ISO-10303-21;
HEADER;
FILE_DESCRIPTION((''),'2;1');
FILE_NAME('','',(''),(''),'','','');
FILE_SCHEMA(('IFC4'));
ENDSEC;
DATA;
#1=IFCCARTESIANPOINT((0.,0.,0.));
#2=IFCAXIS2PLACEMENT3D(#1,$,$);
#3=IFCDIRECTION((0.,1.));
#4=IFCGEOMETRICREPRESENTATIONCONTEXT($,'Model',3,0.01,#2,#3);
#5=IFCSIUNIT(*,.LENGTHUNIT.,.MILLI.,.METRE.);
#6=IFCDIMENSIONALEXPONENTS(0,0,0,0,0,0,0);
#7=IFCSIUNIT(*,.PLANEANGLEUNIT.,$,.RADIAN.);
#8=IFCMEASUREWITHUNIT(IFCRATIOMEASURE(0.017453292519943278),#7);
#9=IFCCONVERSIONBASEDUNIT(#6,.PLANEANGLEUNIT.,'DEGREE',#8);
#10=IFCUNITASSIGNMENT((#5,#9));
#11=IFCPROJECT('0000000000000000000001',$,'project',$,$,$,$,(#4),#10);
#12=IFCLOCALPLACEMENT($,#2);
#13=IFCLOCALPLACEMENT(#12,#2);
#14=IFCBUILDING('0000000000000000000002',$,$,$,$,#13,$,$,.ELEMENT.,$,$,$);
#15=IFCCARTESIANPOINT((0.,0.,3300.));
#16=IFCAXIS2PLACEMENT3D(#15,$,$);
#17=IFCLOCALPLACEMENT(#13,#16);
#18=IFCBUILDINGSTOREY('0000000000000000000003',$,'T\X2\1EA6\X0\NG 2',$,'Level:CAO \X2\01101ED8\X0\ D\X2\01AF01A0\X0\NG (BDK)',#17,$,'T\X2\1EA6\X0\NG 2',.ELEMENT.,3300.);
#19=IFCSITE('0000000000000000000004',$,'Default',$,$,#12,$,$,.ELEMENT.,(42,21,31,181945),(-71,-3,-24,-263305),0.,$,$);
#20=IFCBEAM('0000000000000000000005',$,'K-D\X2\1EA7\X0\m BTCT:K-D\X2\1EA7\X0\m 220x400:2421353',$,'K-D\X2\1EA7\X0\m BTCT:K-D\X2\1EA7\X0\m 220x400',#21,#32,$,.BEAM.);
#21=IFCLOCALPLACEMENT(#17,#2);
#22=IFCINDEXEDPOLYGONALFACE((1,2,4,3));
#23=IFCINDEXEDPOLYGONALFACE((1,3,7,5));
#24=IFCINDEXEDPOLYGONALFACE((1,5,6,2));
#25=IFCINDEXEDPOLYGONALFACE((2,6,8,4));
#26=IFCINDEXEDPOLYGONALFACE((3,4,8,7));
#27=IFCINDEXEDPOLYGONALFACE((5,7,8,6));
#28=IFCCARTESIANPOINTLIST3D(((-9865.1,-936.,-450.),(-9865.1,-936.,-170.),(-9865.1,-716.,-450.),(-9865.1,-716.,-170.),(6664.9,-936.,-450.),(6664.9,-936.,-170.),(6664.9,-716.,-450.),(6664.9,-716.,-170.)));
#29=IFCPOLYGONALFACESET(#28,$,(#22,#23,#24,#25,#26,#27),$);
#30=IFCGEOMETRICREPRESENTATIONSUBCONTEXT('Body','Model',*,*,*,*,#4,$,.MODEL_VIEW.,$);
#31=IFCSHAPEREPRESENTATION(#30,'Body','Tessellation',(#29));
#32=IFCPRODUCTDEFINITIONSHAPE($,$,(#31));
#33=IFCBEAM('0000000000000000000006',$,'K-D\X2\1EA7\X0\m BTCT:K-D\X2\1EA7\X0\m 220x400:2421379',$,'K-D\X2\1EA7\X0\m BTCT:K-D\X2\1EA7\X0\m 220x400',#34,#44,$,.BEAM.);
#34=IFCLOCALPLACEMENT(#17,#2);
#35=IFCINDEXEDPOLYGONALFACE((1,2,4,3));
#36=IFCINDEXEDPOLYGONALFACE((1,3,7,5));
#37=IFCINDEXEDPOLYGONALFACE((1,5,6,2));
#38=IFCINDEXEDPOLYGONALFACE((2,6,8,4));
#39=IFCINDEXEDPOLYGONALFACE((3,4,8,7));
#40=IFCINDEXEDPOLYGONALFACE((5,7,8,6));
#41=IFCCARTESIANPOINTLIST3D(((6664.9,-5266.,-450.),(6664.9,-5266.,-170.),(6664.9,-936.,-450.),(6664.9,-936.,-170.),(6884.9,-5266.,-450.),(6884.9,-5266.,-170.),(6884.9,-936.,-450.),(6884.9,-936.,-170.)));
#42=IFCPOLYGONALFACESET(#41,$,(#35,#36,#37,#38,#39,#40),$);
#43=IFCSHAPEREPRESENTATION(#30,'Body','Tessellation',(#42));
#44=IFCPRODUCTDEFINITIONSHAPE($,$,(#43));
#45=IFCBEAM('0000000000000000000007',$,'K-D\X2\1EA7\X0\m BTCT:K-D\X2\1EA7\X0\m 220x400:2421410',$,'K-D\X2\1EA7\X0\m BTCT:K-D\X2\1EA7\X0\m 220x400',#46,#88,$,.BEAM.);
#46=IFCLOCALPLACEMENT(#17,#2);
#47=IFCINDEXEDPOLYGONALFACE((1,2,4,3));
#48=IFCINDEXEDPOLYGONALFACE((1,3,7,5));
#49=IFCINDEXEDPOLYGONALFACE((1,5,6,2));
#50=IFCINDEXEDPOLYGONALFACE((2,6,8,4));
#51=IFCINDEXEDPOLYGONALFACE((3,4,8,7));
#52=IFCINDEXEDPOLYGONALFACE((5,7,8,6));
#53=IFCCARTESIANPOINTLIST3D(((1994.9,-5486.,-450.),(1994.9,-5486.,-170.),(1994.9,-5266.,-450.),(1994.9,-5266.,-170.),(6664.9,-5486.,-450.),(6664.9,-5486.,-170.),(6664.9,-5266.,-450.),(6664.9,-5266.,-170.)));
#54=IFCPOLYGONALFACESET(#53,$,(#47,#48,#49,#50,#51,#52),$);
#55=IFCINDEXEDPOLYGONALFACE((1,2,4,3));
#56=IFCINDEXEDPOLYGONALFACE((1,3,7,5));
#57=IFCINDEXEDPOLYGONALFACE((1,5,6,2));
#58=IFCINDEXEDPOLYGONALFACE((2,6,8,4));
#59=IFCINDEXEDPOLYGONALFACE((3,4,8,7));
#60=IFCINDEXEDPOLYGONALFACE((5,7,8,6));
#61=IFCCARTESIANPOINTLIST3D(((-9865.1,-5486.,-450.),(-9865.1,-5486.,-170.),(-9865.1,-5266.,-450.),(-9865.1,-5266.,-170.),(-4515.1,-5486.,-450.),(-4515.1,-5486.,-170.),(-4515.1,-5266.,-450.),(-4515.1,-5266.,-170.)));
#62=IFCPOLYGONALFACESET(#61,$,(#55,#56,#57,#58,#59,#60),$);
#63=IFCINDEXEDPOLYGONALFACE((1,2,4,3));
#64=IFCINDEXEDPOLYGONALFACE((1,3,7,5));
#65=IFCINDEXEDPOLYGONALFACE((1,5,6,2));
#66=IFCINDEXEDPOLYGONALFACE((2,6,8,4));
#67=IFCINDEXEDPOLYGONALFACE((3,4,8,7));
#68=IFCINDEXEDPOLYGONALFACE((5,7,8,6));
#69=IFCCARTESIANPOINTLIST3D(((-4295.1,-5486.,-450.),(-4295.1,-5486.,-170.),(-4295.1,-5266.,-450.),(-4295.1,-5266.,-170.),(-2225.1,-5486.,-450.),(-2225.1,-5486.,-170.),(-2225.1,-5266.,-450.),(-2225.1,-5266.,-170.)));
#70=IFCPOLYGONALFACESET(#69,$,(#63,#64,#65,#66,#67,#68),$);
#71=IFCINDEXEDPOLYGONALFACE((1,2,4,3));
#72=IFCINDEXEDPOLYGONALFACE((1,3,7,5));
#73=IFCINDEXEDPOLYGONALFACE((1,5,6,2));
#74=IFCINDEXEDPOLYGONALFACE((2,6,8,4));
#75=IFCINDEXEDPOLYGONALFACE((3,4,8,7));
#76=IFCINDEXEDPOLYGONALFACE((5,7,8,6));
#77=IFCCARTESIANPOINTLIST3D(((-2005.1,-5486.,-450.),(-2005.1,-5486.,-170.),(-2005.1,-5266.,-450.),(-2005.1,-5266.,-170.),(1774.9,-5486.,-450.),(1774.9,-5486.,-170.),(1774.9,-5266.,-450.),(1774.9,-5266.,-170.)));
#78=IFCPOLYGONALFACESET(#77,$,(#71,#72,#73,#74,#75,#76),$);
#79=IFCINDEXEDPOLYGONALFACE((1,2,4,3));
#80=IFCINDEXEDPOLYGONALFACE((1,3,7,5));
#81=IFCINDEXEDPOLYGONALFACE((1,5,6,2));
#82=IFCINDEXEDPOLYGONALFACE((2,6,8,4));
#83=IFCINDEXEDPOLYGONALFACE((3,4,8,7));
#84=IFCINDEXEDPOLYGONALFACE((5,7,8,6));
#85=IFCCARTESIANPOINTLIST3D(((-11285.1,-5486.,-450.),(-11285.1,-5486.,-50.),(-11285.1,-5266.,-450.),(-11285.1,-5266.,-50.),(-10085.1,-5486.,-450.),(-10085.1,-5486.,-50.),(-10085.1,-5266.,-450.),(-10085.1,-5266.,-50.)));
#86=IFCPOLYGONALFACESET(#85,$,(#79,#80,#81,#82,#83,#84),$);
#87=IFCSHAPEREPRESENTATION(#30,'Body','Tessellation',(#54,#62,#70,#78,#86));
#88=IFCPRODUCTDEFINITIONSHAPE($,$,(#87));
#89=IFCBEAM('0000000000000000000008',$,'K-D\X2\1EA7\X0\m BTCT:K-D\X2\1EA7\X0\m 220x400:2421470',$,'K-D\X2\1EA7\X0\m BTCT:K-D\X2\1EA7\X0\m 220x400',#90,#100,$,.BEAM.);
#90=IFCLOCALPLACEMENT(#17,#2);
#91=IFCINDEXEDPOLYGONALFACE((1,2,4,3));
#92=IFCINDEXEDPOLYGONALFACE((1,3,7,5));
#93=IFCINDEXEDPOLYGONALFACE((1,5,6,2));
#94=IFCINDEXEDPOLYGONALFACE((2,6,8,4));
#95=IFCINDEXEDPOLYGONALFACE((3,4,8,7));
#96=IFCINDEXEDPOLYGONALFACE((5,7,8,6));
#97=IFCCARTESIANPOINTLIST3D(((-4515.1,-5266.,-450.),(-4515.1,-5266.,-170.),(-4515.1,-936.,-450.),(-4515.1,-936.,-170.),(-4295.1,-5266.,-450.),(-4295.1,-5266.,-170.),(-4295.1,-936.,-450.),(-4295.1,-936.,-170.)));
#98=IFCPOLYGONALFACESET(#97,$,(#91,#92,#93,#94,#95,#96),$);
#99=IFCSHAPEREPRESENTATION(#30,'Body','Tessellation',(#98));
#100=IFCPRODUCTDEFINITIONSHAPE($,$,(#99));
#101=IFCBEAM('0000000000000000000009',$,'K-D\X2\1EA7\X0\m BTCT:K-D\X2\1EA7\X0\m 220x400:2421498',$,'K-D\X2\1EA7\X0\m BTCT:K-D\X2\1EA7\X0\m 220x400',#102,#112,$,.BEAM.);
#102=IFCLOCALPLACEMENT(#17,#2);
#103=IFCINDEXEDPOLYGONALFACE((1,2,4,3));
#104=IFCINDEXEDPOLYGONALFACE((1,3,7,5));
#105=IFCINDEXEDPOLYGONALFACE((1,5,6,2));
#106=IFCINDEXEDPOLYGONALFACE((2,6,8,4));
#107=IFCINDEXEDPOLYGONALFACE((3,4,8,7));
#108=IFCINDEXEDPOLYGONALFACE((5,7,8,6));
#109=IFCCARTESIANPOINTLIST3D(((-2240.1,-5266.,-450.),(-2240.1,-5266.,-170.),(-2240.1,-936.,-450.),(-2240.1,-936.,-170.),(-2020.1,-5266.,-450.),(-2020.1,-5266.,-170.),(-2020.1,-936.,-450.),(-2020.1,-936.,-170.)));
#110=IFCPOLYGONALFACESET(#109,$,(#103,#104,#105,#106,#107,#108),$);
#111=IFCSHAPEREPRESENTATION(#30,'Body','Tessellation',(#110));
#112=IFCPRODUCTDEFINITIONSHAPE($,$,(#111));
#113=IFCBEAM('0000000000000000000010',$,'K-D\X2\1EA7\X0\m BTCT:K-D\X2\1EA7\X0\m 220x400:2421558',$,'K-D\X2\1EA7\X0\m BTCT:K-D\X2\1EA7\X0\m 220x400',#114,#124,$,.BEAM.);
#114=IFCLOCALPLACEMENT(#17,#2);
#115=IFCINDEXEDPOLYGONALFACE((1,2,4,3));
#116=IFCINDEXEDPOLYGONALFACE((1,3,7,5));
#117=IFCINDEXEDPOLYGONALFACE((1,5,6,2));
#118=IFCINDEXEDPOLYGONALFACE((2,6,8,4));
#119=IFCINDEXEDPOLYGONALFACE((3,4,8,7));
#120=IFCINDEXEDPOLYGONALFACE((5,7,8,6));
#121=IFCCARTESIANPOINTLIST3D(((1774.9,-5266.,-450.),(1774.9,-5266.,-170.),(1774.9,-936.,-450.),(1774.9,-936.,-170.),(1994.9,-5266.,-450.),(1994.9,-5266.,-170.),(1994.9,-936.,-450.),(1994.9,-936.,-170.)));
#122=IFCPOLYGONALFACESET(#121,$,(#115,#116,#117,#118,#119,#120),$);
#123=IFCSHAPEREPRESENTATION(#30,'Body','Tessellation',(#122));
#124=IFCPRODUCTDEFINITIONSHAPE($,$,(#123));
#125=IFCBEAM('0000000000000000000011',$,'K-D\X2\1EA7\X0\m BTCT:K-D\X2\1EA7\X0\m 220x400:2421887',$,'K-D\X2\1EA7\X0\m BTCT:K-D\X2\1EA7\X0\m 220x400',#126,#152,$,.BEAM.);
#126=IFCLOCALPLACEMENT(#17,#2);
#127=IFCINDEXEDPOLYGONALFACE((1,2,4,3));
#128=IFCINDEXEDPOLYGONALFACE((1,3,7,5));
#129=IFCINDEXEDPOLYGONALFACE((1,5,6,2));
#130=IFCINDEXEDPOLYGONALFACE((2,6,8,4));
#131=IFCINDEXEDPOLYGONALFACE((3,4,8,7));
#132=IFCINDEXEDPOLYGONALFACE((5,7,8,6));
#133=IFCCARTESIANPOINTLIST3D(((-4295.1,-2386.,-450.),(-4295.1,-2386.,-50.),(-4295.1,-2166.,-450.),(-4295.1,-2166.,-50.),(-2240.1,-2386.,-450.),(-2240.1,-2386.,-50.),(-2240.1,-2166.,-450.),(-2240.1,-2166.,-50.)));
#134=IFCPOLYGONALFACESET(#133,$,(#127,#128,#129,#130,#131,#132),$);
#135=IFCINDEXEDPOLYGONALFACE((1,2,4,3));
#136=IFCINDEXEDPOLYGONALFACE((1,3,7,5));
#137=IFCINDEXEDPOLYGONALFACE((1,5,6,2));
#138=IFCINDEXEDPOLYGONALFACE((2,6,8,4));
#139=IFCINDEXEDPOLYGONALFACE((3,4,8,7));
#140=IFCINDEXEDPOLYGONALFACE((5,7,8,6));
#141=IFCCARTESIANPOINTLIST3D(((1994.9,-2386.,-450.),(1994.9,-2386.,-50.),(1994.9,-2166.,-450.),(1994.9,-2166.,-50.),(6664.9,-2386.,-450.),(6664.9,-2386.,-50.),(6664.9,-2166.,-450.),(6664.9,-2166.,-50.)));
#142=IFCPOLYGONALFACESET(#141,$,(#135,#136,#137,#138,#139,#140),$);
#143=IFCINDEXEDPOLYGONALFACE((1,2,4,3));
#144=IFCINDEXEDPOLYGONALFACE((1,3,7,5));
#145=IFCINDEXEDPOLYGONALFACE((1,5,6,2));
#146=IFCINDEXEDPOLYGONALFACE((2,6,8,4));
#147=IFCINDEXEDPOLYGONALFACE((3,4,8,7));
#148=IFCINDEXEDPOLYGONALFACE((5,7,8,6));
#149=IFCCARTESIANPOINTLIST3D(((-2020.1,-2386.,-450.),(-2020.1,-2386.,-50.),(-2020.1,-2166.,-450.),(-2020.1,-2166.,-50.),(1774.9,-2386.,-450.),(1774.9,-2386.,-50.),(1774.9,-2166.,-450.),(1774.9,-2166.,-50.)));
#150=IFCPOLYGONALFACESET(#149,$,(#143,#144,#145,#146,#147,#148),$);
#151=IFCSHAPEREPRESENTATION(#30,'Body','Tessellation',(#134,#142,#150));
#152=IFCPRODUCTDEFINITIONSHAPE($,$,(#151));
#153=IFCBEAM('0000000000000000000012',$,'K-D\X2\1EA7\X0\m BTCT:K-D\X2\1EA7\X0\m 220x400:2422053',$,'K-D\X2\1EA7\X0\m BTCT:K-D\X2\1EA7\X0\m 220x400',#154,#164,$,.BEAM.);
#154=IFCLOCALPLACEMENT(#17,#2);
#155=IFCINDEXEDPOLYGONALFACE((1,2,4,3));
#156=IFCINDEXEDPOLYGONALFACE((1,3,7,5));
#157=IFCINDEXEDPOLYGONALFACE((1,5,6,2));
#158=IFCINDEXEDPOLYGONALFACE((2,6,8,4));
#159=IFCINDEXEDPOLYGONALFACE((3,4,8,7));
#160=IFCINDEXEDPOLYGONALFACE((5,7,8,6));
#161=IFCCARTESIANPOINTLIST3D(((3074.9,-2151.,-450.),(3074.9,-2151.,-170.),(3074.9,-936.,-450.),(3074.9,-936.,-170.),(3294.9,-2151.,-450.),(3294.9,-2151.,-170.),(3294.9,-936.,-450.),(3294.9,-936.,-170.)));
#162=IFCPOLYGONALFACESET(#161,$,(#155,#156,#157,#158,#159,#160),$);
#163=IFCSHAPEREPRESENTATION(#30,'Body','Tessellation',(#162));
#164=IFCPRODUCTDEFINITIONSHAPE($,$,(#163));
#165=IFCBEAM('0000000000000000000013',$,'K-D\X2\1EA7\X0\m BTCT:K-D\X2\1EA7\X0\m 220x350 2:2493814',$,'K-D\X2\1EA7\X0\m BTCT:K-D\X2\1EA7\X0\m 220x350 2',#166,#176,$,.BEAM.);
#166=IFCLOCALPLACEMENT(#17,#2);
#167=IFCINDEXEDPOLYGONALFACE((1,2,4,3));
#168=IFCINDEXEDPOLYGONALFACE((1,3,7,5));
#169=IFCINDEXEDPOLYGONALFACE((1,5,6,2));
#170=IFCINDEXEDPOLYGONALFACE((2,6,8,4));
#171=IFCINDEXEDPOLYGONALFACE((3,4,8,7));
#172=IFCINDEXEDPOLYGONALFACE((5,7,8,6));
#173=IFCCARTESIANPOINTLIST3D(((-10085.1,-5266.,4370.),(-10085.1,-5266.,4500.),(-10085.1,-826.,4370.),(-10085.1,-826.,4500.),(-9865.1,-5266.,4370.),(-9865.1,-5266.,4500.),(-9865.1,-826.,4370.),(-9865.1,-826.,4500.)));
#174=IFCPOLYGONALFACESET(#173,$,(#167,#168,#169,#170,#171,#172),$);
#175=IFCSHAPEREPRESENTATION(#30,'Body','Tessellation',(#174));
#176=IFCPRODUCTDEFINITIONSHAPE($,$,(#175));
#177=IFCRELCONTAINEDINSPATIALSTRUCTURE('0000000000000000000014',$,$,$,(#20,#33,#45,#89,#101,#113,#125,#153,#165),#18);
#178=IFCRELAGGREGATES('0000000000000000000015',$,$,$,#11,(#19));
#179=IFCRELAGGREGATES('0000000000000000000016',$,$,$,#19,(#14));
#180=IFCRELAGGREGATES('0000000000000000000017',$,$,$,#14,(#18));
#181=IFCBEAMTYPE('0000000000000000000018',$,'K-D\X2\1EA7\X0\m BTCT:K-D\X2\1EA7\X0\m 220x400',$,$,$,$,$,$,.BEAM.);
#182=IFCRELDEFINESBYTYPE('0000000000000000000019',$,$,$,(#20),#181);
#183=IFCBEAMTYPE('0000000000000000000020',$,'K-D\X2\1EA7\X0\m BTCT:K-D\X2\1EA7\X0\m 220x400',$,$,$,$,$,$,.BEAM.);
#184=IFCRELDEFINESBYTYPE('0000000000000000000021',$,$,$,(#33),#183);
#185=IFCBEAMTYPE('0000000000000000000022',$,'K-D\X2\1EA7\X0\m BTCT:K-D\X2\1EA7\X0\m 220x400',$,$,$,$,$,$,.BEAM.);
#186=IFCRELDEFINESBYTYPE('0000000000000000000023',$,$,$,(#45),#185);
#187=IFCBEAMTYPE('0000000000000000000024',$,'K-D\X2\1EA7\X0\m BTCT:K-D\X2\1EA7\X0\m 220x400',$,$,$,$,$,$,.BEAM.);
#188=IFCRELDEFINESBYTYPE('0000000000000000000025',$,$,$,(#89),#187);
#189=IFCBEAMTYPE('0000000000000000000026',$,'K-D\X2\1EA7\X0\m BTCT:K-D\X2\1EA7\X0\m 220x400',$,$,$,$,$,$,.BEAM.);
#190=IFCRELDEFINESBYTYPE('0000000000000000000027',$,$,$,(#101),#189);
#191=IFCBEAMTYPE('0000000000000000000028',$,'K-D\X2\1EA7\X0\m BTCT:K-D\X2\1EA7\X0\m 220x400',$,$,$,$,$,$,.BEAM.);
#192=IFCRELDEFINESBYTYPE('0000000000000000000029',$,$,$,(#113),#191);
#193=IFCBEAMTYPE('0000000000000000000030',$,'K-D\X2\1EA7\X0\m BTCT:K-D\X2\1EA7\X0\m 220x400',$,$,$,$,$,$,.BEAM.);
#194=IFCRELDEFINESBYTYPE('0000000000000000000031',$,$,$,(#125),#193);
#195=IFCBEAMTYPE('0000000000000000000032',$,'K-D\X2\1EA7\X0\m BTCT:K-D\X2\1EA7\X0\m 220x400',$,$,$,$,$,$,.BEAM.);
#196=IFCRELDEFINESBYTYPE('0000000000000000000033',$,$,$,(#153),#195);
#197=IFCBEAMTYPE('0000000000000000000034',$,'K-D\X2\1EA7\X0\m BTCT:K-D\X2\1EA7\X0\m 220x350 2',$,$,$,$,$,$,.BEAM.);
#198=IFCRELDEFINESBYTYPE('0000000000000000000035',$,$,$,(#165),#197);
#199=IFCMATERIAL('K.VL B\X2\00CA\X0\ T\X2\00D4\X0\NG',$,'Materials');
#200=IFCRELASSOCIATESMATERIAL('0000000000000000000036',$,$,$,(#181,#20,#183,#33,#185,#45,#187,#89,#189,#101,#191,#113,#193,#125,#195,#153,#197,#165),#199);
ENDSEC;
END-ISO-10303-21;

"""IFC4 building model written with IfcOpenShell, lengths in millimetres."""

from ifc_helpers import new_model, entity, si_unit, converted_unit, direction, frame, origin, place, context, subcontext, project, spatial, indexed_curve, outline, extrude, source, transform, mapped, material, type_object, type_shapes, element, save


model = new_model("IFC4")

# Units and contexts
model_context = context("Model", 3, precision=0.01, world=origin(), true_north=direction((0.0, 1.0)))
body_context = subcontext(model_context, "Body", "Model", "MODEL_VIEW")
ifc_project = project(units=[si_unit("LENGTHUNIT", "METRE", prefix="MILLI"), converted_unit("PLANEANGLEUNIT", "DEGREE", entity("IfcRatioMeasure", 0.017453292519943278), si_unit("PLANEANGLEUNIT", "RADIAN"), dimensions=[0, 0, 0, 0, 0, 0, 0])], contexts=[model_context])

# Site, building, storey
site_placement = place(None, origin())
site = spatial("IfcSite", under=ifc_project, at=site_placement, Name="Default", CompositionType="ELEMENT", RefLatitude=(42, 21, 31, 181945), RefLongitude=(-71, -3, -24, -263305), RefElevation=0.0)
building_placement = place(site_placement, origin())
building = spatial("IfcBuilding", under=site, at=building_placement, CompositionType="ELEMENT")
storey_placement = place(building_placement, frame((0.0, 0.0, 3300.0)))
storey = spatial("IfcBuildingStorey", under=building, at=storey_placement, Name="TẦNG 2", ObjectType="Level:CAO ĐỘ DƯƠNG (BDK)", LongName="TẦNG 2", CompositionType="ELEMENT", Elevation=3300.0)

# Beams
ifc_material_1 = material(Name="K.VL BÊ TÔNG", Category="Materials")
beam_type_1 = type_object("IfcBeamType", Name="K-Dầm BTCT:K-Dầm 220x400", PredefinedType="BEAM", material=ifc_material_1)
shared_shape_1 = source(origin(), body_context, "Body", "SweptSolid", [
    extrude(outline(indexed_curve([(-140.0, -110.0), (140.0, -110.0), (140.0, 110.0), (-140.0, 110.0), (-140.0, -110.0)], self_intersect=False)), frame((-9865.1, -826.0, 2990.0), z_axis=(1.0, 0.0, 0.0), x_axis=(0.0, 0.0, -1.0)), (0.0, 0.0, 1.0), 16530.0),
])
type_shapes(beam_type_1, [shared_shape_1])
beam_1_placement = place(storey_placement, frame((0.0, 0.0, -3300.0)))
element("IfcBeam", 1, at=beam_1_placement, inside=storey, type_object=beam_type_1, material=ifc_material_1, Name="K-Dầm BTCT:K-Dầm 220x400:2421353", ObjectType="K-Dầm BTCT:K-Dầm 220x400", PredefinedType="BEAM", context=body_context, shape_type="MappedRepresentation", body=[
    mapped(shared_shape_1, transform((0.0, 0.0, 0.0), scale=1.0)),
])
beam_type_2 = type_object("IfcBeamType", Name="K-Dầm BTCT:K-Dầm 220x400", PredefinedType="BEAM", material=ifc_material_1)
shared_shape_2 = source(origin(), body_context, "Body", "SweptSolid", [
    extrude(outline(indexed_curve([(-110.0, -140.0), (110.0, -140.0), (110.0, 140.0), (-110.0, 140.0), (-110.0, -140.0)], self_intersect=False)), frame((6774.9, -936.0, 2990.0), z_axis=(0.0, -1.0, 0.0), x_axis=(-1.0, 0.0, 0.0)), (0.0, 0.0, 1.0), 4330.0),
])
type_shapes(beam_type_2, [shared_shape_2])
beam_2_placement = place(storey_placement, frame((0.0, 0.0, -3300.0)))
element("IfcBeam", 2, at=beam_2_placement, inside=storey, type_object=beam_type_2, material=ifc_material_1, Name="K-Dầm BTCT:K-Dầm 220x400:2421379", ObjectType="K-Dầm BTCT:K-Dầm 220x400", PredefinedType="BEAM", context=body_context, shape_type="MappedRepresentation", body=[
    mapped(shared_shape_2, transform((0.0, 0.0, 0.0), scale=1.0)),
])
beam_type_3 = type_object("IfcBeamType", Name="K-Dầm BTCT:K-Dầm 220x400", PredefinedType="BEAM", material=ifc_material_1)
shared_shape_3 = source(origin(), body_context, "Body", "SweptSolid", [
    extrude(outline(indexed_curve([(-140.0, -110.0), (140.0, -110.0), (140.0, 110.0), (-140.0, 110.0), (-140.0, -110.0)], self_intersect=False)), frame((6664.9, -5376.0, 2990.0), z_axis=(-1.0, 0.0, 0.0), x_axis=(0.0, 0.0, -1.0)), (0.0, 0.0, 1.0), 4670.0),
    extrude(outline(indexed_curve([(-140.0, -110.0), (140.0, -110.0), (140.0, 110.0), (-140.0, 110.0), (-140.0, -110.0)], self_intersect=False)), frame((-4515.1, -5376.0, 2990.0), z_axis=(-1.0, 0.0, 0.0), x_axis=(0.0, 0.0, -1.0)), (0.0, 0.0, 1.0), 5350.0),
    extrude(outline(indexed_curve([(-140.0, -110.0), (140.0, -110.0), (140.0, 110.0), (-140.0, 110.0), (-140.0, -110.0)], self_intersect=False)), frame((-2225.1, -5376.0, 2990.0), z_axis=(-1.0, 0.0, 0.0), x_axis=(0.0, 0.0, -1.0)), (0.0, 0.0, 1.0), 2070.0),
    extrude(outline(indexed_curve([(-140.0, -110.0), (140.0, -110.0), (140.0, 110.0), (-140.0, 110.0), (-140.0, -110.0)], self_intersect=False)), frame((1774.9, -5376.0, 2990.0), z_axis=(-1.0, 0.0, 0.0), x_axis=(0.0, 0.0, -1.0)), (0.0, 0.0, 1.0), 3780.0),
    extrude(outline(indexed_curve([(-200.0, -110.0), (200.0, -110.0), (200.0, 110.0), (-200.0, 110.0), (-200.0, -110.0)], self_intersect=False)), frame((-10085.1, -5376.0, 3050.0), z_axis=(-1.0, 0.0, 0.0), x_axis=(0.0, 0.0, -1.0)), (0.0, 0.0, 1.0), 1200.0),
])
type_shapes(beam_type_3, [shared_shape_3])
beam_3_placement = place(storey_placement, frame((0.0, 0.0, -3300.0)))
element("IfcBeam", 3, at=beam_3_placement, inside=storey, type_object=beam_type_3, material=ifc_material_1, Name="K-Dầm BTCT:K-Dầm 220x400:2421410", ObjectType="K-Dầm BTCT:K-Dầm 220x400", PredefinedType="BEAM", context=body_context, shape_type="MappedRepresentation", body=[
    mapped(shared_shape_3, transform((0.0, 0.0, 0.0), scale=1.0)),
])
beam_type_4 = type_object("IfcBeamType", Name="K-Dầm BTCT:K-Dầm 220x400", PredefinedType="BEAM", material=ifc_material_1)
shared_shape_4 = source(origin(), body_context, "Body", "SweptSolid", [
    extrude(outline(indexed_curve([(-110.0, -140.0), (110.0, -140.0), (110.0, 140.0), (-110.0, 140.0), (-110.0, -140.0)], self_intersect=False)), frame((-4405.1, -936.0, 2990.0), z_axis=(0.0, -1.0, 0.0), x_axis=(-1.0, 0.0, 0.0)), (0.0, 0.0, 1.0), 4330.0),
])
type_shapes(beam_type_4, [shared_shape_4])
beam_4_placement = place(storey_placement, frame((0.0, 0.0, -3300.0)))
element("IfcBeam", 4, at=beam_4_placement, inside=storey, type_object=beam_type_4, material=ifc_material_1, Name="K-Dầm BTCT:K-Dầm 220x400:2421470", ObjectType="K-Dầm BTCT:K-Dầm 220x400", PredefinedType="BEAM", context=body_context, shape_type="MappedRepresentation", body=[
    mapped(shared_shape_4, transform((0.0, 0.0, 0.0), scale=1.0)),
])
beam_type_5 = type_object("IfcBeamType", Name="K-Dầm BTCT:K-Dầm 220x400", PredefinedType="BEAM", material=ifc_material_1)
shared_shape_5 = source(origin(), body_context, "Body", "SweptSolid", [
    extrude(outline(indexed_curve([(-110.0, -140.0), (110.0, -140.0), (110.0, 140.0), (-110.0, 140.0), (-110.0, -140.0)], self_intersect=False)), frame((-2130.1, -936.0, 2990.0), z_axis=(0.0, -1.0, 0.0), x_axis=(-1.0, 0.0, 0.0)), (0.0, 0.0, 1.0), 4330.0),
])
type_shapes(beam_type_5, [shared_shape_5])
beam_5_placement = place(storey_placement, frame((0.0, 0.0, -3300.0)))
element("IfcBeam", 5, at=beam_5_placement, inside=storey, type_object=beam_type_5, material=ifc_material_1, Name="K-Dầm BTCT:K-Dầm 220x400:2421498", ObjectType="K-Dầm BTCT:K-Dầm 220x400", PredefinedType="BEAM", context=body_context, shape_type="MappedRepresentation", body=[
    mapped(shared_shape_5, transform((0.0, 0.0, 0.0), scale=1.0)),
])
beam_type_6 = type_object("IfcBeamType", Name="K-Dầm BTCT:K-Dầm 220x400", PredefinedType="BEAM", material=ifc_material_1)
shared_shape_6 = source(origin(), body_context, "Body", "SweptSolid", [
    extrude(outline(indexed_curve([(-110.0, -140.0), (110.0, -140.0), (110.0, 140.0), (-110.0, 140.0), (-110.0, -140.0)], self_intersect=False)), frame((1884.9, -936.0, 2990.0), z_axis=(0.0, -1.0, 0.0), x_axis=(-1.0, 0.0, 0.0)), (0.0, 0.0, 1.0), 4330.0),
])
type_shapes(beam_type_6, [shared_shape_6])
beam_6_placement = place(storey_placement, frame((0.0, 0.0, -3300.0)))
element("IfcBeam", 6, at=beam_6_placement, inside=storey, type_object=beam_type_6, material=ifc_material_1, Name="K-Dầm BTCT:K-Dầm 220x400:2421558", ObjectType="K-Dầm BTCT:K-Dầm 220x400", PredefinedType="BEAM", context=body_context, shape_type="MappedRepresentation", body=[
    mapped(shared_shape_6, transform((0.0, 0.0, 0.0), scale=1.0)),
])
beam_type_7 = type_object("IfcBeamType", Name="K-Dầm BTCT:K-Dầm 220x400", PredefinedType="BEAM", material=ifc_material_1)
shared_shape_7 = source(origin(), body_context, "Body", "SweptSolid", [
    extrude(outline(indexed_curve([(-200.0, -110.0), (200.0, -110.0), (200.0, 110.0), (-200.0, 110.0), (-200.0, -110.0)], self_intersect=False)), frame((-4295.1, -2276.0, 3050.0), z_axis=(1.0, 0.0, 0.0), x_axis=(0.0, 0.0, -1.0)), (0.0, 0.0, 1.0), 2055.0),
    extrude(outline(indexed_curve([(-200.0, -110.0), (200.0, -110.0), (200.0, 110.0), (-200.0, 110.0), (-200.0, -110.0)], self_intersect=False)), frame((1994.9, -2276.0, 3050.0), z_axis=(1.0, 0.0, 0.0), x_axis=(0.0, 0.0, -1.0)), (0.0, 0.0, 1.0), 4670.0),
    extrude(outline(indexed_curve([(-200.0, -110.0), (200.0, -110.0), (200.0, 110.0), (-200.0, 110.0), (-200.0, -110.0)], self_intersect=False)), frame((-2020.1, -2276.0, 3050.0), z_axis=(1.0, 0.0, 0.0), x_axis=(0.0, 0.0, -1.0)), (0.0, 0.0, 1.0), 3795.0),
])
type_shapes(beam_type_7, [shared_shape_7])
beam_7_placement = place(storey_placement, frame((0.0, 0.0, -3300.0)))
element("IfcBeam", 7, at=beam_7_placement, inside=storey, type_object=beam_type_7, material=ifc_material_1, Name="K-Dầm BTCT:K-Dầm 220x400:2421887", ObjectType="K-Dầm BTCT:K-Dầm 220x400", PredefinedType="BEAM", context=body_context, shape_type="MappedRepresentation", body=[
    mapped(shared_shape_7, transform((0.0, 0.0, 0.0), scale=1.0)),
])
beam_type_8 = type_object("IfcBeamType", Name="K-Dầm BTCT:K-Dầm 220x400", PredefinedType="BEAM", material=ifc_material_1)
shared_shape_8 = source(origin(), body_context, "Body", "SweptSolid", [
    extrude(outline(indexed_curve([(-110.0, -140.0), (110.0, -140.0), (110.0, 140.0), (-110.0, 140.0), (-110.0, -140.0)], self_intersect=False)), frame((3184.9, -936.0, 2990.0), z_axis=(0.0, -1.0, 0.0), x_axis=(-1.0, 0.0, 0.0)), (0.0, 0.0, 1.0), 1215.0),
])
type_shapes(beam_type_8, [shared_shape_8])
beam_8_placement = place(storey_placement, frame((0.0, 0.0, -3300.0)))
element("IfcBeam", 8, at=beam_8_placement, inside=storey, type_object=beam_type_8, material=ifc_material_1, Name="K-Dầm BTCT:K-Dầm 220x400:2422053", ObjectType="K-Dầm BTCT:K-Dầm 220x400", PredefinedType="BEAM", context=body_context, shape_type="MappedRepresentation", body=[
    mapped(shared_shape_8, transform((0.0, 0.0, 0.0), scale=1.0)),
])
beam_type_9 = type_object("IfcBeamType", Name="K-Dầm BTCT:K-Dầm 220x350 2", PredefinedType="BEAM", material=ifc_material_1)
shared_shape_9 = source(origin(), body_context, "Body", "SweptSolid", [
    extrude(outline(indexed_curve([(-110.0, -65.0), (110.0, -65.0), (110.0, 65.0), (-110.0, 65.0), (-110.0, -65.0)], self_intersect=False)), frame((-9975.1, -826.0, 7735.0), z_axis=(0.0, -1.0, 0.0), x_axis=(-1.0, 0.0, 0.0)), (0.0, 0.0, 1.0), 4440.0),
])
type_shapes(beam_type_9, [shared_shape_9])
beam_9_placement = place(storey_placement, frame((0.0, 0.0, -3300.0)))
element("IfcBeam", 9, at=beam_9_placement, inside=storey, type_object=beam_type_9, material=ifc_material_1, Name="K-Dầm BTCT:K-Dầm 220x350 2:2493814", ObjectType="K-Dầm BTCT:K-Dầm 220x350 2", PredefinedType="BEAM", context=body_context, shape_type="MappedRepresentation", body=[
    mapped(shared_shape_9, transform((0.0, 0.0, 0.0), scale=1.0)),
])

save(model, "model.ifc")
